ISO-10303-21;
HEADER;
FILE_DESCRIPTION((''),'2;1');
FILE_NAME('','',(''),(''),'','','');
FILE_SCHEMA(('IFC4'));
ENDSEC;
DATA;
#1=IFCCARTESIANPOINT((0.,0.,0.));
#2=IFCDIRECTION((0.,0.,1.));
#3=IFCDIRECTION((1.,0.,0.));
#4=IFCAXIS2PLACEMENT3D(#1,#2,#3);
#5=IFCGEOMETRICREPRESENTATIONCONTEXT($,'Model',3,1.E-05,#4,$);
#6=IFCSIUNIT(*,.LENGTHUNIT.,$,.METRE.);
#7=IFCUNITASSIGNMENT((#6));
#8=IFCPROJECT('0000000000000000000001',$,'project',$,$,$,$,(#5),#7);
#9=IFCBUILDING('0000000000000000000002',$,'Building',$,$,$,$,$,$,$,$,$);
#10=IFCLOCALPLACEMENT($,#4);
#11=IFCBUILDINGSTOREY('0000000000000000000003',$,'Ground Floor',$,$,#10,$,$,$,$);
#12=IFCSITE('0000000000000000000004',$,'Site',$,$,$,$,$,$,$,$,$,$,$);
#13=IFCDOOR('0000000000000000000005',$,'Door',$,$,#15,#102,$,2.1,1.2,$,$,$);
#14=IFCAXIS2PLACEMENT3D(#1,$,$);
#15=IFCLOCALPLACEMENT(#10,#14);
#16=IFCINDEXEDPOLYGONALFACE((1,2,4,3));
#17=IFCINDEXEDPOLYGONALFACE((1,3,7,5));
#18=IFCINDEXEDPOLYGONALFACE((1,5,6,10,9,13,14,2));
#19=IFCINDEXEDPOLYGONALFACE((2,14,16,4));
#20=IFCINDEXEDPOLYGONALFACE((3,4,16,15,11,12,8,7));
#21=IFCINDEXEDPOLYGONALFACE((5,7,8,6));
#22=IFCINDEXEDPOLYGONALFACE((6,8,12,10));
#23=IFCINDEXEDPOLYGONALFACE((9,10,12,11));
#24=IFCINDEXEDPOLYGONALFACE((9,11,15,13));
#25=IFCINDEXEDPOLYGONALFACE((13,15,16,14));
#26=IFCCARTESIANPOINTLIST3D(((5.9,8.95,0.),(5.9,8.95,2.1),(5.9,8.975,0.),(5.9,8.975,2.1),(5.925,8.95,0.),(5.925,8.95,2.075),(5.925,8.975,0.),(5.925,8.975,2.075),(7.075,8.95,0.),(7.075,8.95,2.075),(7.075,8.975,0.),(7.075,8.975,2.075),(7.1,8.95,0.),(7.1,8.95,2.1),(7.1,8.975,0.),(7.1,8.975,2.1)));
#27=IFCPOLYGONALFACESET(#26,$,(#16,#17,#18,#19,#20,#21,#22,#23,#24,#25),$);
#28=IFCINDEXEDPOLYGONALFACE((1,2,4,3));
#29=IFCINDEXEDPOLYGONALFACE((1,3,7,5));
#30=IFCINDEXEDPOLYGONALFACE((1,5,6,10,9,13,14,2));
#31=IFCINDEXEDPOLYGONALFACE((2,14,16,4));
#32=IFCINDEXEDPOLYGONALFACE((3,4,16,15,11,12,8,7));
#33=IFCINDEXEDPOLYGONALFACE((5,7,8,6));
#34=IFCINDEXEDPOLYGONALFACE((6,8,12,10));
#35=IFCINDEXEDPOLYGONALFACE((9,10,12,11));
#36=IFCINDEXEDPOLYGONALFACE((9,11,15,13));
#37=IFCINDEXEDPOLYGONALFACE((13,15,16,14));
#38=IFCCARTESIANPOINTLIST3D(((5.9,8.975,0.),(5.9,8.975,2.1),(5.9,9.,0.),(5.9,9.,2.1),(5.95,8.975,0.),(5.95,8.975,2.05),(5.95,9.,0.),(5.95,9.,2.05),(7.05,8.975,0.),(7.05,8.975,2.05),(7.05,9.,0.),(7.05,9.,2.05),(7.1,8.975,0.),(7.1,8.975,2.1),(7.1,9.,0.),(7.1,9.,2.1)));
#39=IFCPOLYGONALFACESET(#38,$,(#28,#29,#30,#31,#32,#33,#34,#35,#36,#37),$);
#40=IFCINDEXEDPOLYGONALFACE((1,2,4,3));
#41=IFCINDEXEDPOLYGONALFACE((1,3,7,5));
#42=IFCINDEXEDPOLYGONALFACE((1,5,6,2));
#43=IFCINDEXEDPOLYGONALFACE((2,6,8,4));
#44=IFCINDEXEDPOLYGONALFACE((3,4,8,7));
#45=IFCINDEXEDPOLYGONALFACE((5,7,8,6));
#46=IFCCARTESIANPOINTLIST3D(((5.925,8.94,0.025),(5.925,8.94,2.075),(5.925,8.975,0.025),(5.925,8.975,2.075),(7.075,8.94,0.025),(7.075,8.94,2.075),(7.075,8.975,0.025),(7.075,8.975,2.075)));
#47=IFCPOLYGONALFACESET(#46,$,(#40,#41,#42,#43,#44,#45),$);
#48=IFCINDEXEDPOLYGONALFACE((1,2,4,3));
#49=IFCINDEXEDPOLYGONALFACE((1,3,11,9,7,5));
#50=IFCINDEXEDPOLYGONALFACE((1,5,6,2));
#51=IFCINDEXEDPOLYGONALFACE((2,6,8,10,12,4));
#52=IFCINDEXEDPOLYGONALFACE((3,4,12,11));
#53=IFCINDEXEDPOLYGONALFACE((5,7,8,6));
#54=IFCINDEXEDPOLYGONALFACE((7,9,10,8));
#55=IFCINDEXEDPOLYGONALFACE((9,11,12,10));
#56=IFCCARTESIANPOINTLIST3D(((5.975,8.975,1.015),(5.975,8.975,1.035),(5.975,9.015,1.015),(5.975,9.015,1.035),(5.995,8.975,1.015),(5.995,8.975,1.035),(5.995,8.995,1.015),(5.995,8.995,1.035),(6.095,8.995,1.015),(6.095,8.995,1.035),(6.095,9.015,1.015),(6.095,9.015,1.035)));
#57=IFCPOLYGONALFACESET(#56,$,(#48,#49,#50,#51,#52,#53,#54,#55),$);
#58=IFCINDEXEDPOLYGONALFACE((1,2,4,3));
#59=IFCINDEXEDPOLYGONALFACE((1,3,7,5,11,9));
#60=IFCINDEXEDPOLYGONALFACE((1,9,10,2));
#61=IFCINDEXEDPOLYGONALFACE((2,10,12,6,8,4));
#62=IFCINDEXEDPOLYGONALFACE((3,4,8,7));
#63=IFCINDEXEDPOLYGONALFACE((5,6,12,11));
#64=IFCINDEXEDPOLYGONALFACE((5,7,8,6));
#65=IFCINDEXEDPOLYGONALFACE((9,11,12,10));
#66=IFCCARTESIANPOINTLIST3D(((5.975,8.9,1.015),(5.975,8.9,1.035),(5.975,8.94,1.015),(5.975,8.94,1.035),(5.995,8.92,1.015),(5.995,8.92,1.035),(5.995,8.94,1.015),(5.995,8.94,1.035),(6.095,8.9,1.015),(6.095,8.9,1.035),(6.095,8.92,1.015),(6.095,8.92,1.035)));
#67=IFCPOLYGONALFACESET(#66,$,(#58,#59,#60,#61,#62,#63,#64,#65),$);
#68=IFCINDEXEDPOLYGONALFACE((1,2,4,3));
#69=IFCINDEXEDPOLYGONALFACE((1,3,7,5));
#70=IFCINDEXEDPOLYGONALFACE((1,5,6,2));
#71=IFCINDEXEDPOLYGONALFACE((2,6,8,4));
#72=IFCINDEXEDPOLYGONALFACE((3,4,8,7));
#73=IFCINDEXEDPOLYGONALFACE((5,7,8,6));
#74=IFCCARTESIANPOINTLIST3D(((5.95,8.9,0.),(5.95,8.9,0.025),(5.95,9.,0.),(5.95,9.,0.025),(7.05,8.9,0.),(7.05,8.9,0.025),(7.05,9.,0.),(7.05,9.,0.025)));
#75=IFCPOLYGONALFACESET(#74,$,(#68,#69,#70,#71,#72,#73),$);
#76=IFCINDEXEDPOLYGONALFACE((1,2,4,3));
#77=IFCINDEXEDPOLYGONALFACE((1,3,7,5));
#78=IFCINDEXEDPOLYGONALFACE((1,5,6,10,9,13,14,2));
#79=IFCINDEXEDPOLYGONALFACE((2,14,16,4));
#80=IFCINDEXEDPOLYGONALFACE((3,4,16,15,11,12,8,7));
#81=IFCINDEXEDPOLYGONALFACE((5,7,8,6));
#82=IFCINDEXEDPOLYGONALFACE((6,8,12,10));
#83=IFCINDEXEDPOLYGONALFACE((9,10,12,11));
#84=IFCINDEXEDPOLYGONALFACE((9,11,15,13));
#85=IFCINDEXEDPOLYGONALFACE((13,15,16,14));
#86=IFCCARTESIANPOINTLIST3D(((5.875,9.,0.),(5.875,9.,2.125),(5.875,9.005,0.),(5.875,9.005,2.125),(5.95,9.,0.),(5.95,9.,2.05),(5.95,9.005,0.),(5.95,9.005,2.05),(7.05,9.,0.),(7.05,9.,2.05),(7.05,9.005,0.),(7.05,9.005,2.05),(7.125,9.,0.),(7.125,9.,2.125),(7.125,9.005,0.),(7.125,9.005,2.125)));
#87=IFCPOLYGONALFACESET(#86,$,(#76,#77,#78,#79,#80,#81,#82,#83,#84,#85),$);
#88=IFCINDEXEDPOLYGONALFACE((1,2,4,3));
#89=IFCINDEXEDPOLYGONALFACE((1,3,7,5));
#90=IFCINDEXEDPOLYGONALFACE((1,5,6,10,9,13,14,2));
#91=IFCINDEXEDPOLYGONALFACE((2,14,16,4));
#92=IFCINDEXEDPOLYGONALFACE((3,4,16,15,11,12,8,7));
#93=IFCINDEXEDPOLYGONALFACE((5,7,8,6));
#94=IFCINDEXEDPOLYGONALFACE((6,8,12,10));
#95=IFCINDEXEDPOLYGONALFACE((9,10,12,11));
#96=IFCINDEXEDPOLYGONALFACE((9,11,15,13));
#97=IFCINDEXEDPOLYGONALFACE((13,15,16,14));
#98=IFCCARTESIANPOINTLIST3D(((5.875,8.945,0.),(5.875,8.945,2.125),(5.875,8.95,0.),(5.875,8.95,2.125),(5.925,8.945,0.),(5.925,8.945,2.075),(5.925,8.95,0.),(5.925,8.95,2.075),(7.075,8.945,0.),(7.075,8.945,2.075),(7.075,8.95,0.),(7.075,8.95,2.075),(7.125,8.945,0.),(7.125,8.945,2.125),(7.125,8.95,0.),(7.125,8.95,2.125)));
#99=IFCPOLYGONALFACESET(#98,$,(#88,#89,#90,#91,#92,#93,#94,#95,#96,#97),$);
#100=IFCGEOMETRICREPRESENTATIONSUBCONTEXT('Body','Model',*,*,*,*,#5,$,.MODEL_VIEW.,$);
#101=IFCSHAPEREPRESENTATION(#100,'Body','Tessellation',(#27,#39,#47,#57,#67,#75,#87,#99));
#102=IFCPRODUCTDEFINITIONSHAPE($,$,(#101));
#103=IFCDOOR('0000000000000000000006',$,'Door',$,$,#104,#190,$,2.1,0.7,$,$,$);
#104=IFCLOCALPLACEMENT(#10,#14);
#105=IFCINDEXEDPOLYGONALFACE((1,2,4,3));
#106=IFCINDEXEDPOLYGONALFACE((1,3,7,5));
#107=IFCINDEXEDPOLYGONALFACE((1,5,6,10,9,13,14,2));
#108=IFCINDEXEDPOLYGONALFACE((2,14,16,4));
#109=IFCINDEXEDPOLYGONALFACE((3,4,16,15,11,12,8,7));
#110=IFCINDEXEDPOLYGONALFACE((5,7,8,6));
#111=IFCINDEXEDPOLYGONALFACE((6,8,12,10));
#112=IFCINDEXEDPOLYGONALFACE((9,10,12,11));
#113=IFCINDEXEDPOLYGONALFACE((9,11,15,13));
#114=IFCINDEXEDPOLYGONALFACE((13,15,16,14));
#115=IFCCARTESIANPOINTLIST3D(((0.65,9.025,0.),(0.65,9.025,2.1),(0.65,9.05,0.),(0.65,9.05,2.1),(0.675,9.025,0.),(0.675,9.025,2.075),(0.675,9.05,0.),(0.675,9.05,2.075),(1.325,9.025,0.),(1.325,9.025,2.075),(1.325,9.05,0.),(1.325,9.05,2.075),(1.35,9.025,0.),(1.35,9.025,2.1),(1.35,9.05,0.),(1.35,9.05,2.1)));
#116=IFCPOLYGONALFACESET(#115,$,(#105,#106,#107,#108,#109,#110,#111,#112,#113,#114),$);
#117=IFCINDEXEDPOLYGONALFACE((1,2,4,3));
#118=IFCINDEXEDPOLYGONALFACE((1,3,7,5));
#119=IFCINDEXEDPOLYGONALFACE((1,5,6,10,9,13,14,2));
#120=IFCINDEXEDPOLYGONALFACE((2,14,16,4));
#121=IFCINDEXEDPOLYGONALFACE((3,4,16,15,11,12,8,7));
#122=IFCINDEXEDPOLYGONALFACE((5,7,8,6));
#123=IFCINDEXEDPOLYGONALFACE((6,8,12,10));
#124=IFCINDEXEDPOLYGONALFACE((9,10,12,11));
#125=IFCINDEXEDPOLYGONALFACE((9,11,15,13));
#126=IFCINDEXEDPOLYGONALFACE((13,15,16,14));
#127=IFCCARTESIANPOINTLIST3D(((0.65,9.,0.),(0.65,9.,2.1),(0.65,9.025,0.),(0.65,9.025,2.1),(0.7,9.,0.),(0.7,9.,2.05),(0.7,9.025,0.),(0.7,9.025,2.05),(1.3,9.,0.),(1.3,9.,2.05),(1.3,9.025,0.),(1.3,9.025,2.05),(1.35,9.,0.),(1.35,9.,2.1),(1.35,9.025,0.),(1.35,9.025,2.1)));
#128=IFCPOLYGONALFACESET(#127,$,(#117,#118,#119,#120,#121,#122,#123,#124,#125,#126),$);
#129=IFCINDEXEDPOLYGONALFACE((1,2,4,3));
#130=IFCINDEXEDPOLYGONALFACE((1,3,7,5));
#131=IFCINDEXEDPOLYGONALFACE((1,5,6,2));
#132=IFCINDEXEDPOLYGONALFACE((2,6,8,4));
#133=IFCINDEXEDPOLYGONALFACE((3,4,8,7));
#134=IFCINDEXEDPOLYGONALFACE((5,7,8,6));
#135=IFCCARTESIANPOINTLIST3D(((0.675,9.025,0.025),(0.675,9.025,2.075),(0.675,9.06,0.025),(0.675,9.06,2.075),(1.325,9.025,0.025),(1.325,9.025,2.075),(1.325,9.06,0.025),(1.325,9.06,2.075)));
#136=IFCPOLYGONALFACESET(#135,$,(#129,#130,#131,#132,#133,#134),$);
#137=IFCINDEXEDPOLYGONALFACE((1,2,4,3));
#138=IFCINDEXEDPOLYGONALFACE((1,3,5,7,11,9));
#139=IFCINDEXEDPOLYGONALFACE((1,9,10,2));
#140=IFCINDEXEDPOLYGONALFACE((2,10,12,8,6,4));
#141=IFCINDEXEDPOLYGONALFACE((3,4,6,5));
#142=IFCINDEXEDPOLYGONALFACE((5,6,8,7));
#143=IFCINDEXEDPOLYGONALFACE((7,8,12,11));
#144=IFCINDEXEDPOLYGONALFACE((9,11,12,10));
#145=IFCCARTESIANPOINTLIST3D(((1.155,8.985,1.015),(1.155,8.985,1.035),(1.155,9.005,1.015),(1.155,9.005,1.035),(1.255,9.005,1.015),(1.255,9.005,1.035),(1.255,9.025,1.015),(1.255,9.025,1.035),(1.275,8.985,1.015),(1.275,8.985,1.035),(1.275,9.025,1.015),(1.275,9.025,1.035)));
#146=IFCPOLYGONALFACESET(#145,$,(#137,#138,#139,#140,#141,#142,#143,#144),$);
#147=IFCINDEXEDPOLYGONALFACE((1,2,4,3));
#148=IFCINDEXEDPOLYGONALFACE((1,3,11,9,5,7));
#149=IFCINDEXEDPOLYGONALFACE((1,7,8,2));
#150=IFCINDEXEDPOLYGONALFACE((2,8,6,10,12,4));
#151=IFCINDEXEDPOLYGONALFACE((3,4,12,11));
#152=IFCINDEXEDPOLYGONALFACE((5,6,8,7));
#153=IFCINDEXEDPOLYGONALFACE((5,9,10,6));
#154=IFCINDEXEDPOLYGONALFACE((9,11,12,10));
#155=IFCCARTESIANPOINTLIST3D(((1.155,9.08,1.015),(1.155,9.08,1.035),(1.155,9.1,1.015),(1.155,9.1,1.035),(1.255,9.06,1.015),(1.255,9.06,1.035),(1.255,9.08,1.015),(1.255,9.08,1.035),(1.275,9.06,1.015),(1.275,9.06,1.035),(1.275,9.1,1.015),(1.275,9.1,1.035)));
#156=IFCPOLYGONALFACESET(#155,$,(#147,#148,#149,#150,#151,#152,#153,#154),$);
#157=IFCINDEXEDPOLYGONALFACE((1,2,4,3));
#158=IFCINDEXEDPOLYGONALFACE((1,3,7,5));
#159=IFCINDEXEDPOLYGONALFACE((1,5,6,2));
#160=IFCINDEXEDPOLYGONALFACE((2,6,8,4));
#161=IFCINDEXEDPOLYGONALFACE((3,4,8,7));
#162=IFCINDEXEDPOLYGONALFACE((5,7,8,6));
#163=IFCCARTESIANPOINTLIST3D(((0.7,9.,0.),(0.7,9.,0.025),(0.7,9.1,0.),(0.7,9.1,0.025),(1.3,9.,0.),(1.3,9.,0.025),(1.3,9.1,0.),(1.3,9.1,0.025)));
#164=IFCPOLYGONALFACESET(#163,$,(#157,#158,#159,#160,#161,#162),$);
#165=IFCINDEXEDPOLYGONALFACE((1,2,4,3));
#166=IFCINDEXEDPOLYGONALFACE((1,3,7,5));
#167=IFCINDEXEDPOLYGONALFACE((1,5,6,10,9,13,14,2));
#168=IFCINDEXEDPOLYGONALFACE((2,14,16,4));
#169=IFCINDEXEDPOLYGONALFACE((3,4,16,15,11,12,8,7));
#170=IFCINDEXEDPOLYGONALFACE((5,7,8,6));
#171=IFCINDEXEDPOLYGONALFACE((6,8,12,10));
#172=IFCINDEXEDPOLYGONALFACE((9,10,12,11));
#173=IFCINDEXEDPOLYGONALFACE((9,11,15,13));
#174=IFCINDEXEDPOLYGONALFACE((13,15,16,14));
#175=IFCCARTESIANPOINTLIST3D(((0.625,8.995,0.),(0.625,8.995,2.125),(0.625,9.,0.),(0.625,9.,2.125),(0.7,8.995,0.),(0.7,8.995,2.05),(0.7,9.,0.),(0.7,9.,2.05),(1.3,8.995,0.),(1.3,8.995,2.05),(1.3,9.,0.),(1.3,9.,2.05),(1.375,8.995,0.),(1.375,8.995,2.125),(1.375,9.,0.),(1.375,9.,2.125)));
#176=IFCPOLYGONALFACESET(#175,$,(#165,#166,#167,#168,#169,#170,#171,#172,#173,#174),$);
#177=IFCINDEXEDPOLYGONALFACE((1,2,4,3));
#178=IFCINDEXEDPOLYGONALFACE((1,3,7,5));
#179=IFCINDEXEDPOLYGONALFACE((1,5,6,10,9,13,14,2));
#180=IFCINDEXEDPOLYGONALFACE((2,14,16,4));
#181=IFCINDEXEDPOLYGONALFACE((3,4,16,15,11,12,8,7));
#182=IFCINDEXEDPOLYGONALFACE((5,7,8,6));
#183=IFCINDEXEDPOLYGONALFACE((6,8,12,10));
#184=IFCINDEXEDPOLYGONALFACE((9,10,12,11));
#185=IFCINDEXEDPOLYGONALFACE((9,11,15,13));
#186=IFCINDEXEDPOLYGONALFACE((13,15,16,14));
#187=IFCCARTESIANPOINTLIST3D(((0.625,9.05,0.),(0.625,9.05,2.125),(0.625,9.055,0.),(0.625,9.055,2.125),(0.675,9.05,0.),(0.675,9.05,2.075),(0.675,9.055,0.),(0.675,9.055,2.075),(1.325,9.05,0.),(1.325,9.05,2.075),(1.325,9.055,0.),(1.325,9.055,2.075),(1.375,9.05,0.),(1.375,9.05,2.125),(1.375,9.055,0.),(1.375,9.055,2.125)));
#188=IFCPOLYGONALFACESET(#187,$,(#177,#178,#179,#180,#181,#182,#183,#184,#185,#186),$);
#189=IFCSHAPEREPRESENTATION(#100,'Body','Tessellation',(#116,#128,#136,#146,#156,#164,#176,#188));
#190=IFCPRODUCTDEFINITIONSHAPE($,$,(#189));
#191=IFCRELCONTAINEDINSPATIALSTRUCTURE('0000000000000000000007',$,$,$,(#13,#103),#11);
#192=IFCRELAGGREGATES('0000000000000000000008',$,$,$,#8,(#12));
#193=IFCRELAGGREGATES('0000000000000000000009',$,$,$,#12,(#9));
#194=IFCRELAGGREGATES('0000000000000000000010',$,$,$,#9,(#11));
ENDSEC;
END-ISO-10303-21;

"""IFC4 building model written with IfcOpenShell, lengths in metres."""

from ifc_helpers import new_model, si_unit, frame, origin_with_axes, place, context, subcontext, project, spatial, line, indexed_curve, outline, extrude, element, save


model = new_model("IFC4")

# Units and contexts
model_context = context("Model", 3, precision=1e-05, world=origin_with_axes())
body_context = subcontext(model_context, "Body", "Model", "MODEL_VIEW")
ifc_project = project(units=[si_unit("LENGTHUNIT", "METRE")], contexts=[model_context])

# Site, building, storey
site = spatial("IfcSite", under=ifc_project, Name="Site")
building = spatial("IfcBuilding", under=site, Name="Building")
storey_placement = place(None, origin_with_axes())
storey = spatial("IfcBuildingStorey", under=building, at=storey_placement, Name="Ground Floor")

# Doors
door_1_placement = place(storey_placement, frame((7.1, 9.0, 0.0), z_axis=(0.0, 0.0, 1.0), x_axis=(-1.0, 0.0, 0.0)))
element("IfcDoor", 1, at=door_1_placement, inside=storey, Name="Door", OverallHeight=2.1, OverallWidth=1.2, context=body_context, shape_type="SweptSolid", body=[
    extrude(outline(indexed_curve([(0.0, 0.0), (0.0, 2.1), (1.2, 2.1), (1.2, 0.0), (1.175, 0.0), (1.175, 2.075), (0.025, 2.075), (0.025, 0.0)], segments=[line(1, 2, 3, 4, 5, 6, 7, 8, 1)])), frame((0.0, 0.025, 0.0), z_axis=(0.0, -1.0, 0.0), x_axis=(1.0, 0.0, 0.0)), (0.0, 0.0, -1.0), 0.025),
    extrude(outline(indexed_curve([(0.0, 0.0), (0.0, 2.1), (1.2, 2.1), (1.2, 0.0), (1.15, 0.0), (1.15, 2.05), (0.05, 2.05), (0.05, 0.0)], segments=[line(1, 2, 3, 4, 5, 6, 7, 8, 1)])), frame((0.0, 0.0, 0.0), z_axis=(0.0, -1.0, 0.0), x_axis=(1.0, 0.0, 0.0)), (0.0, 0.0, -1.0), 0.025),
    extrude(outline(indexed_curve([(0.0, 0.0), (1.15, 0.0), (1.15, 0.035), (0.0, 0.035)], segments=[line(1, 2, 3, 4, 1)])), frame((0.025, 0.025, 0.025), z_axis=(0.0, 0.0, 1.0), x_axis=(1.0, 0.0, 0.0)), (0.0, 0.0, 1.0), 2.05),
    extrude(outline(indexed_curve([(0.0, 0.0), (0.0, -0.04), (-0.12, -0.04), (-0.12, -0.02), (-0.02, -0.02), (-0.02, 0.0)], segments=[line(1, 2, 3, 4, 5, 6, 1)])), frame((1.125, 0.025, 1.015), z_axis=(0.0, 0.0, 1.0), x_axis=(1.0, 0.0, 0.0)), (0.0, 0.0, 1.0), 0.02),
    extrude(outline(indexed_curve([(0.0, 0.0), (0.0, 0.04), (-0.12, 0.04), (-0.12, 0.02), (-0.02, 0.02), (-0.02, 0.0)], segments=[line(1, 2, 3, 4, 5, 6, 1)])), frame((1.125, 0.06, 1.015), z_axis=(0.0, 0.0, 1.0), x_axis=(1.0, 0.0, 0.0)), (0.0, 0.0, 1.0), 0.02),
    extrude(outline(indexed_curve([(0.0, 0.0), (1.1, 0.0), (1.1, 0.1), (0.0, 0.1)], segments=[line(1, 2, 3, 4, 1)])), frame((0.05, 0.0, 0.0), z_axis=(0.0, 0.0, 1.0), x_axis=(1.0, 0.0, 0.0)), (0.0, 0.0, 1.0), 0.025),
    extrude(outline(indexed_curve([(0.0, 0.0), (0.0, 2.125), (1.25, 2.125), (1.25, 0.0), (1.175, 0.0), (1.175, 2.05), (0.075, 2.05), (0.075, 0.0)], segments=[line(1, 2, 3, 4, 5, 6, 7, 8, 1)])), frame((-0.025, -0.005, 0.0), z_axis=(0.0, -1.0, 0.0), x_axis=(1.0, 0.0, 0.0)), (0.0, 0.0, -1.0), 0.005),
    extrude(outline(indexed_curve([(0.0, 0.0), (0.0, 2.125), (1.25, 2.125), (1.25, 0.0), (1.2, 0.0), (1.2, 2.075), (0.05, 2.075), (0.05, 0.0)], segments=[line(1, 2, 3, 4, 5, 6, 7, 8, 1)])), frame((-0.025, 0.05, 0.0), z_axis=(0.0, -1.0, 0.0), x_axis=(1.0, 0.0, 0.0)), (0.0, 0.0, -1.0), 0.005),
])
door_2_placement = place(storey_placement, frame((0.65, 9.0, 0.0), z_axis=(0.0, 0.0, 1.0), x_axis=(1.0, 0.0, 0.0)))
element("IfcDoor", 2, at=door_2_placement, inside=storey, Name="Door", OverallHeight=2.1, OverallWidth=0.7, context=body_context, shape_type="SweptSolid", body=[
    extrude(outline(indexed_curve([(0.0, 0.0), (0.0, 2.1), (0.7, 2.1), (0.7, 0.0), (0.675, 0.0), (0.675, 2.075), (0.025, 2.075), (0.025, 0.0)], segments=[line(1, 2, 3, 4, 5, 6, 7, 8, 1)])), frame((0.0, 0.025, 0.0), z_axis=(0.0, -1.0, 0.0), x_axis=(1.0, 0.0, 0.0)), (0.0, 0.0, -1.0), 0.025),
    extrude(outline(indexed_curve([(0.0, 0.0), (0.0, 2.1), (0.7, 2.1), (0.7, 0.0), (0.65, 0.0), (0.65, 2.05), (0.05, 2.05), (0.05, 0.0)], segments=[line(1, 2, 3, 4, 5, 6, 7, 8, 1)])), frame((0.0, 0.0, 0.0), z_axis=(0.0, -1.0, 0.0), x_axis=(1.0, 0.0, 0.0)), (0.0, 0.0, -1.0), 0.025),
    extrude(outline(indexed_curve([(0.0, 0.0), (0.65, 0.0), (0.65, 0.035), (0.0, 0.035)], segments=[line(1, 2, 3, 4, 1)])), frame((0.025, 0.025, 0.025), z_axis=(0.0, 0.0, 1.0), x_axis=(1.0, 0.0, 0.0)), (0.0, 0.0, 1.0), 2.05),
    extrude(outline(indexed_curve([(0.0, 0.0), (0.0, -0.04), (-0.12, -0.04), (-0.12, -0.02), (-0.02, -0.02), (-0.02, 0.0)], segments=[line(1, 2, 3, 4, 5, 6, 1)])), frame((0.625, 0.025, 1.015), z_axis=(0.0, 0.0, 1.0), x_axis=(1.0, 0.0, 0.0)), (0.0, 0.0, 1.0), 0.02),
    extrude(outline(indexed_curve([(0.0, 0.0), (0.0, 0.04), (-0.12, 0.04), (-0.12, 0.02), (-0.02, 0.02), (-0.02, 0.0)], segments=[line(1, 2, 3, 4, 5, 6, 1)])), frame((0.625, 0.06, 1.015), z_axis=(0.0, 0.0, 1.0), x_axis=(1.0, 0.0, 0.0)), (0.0, 0.0, 1.0), 0.02),
    extrude(outline(indexed_curve([(0.0, 0.0), (0.6, 0.0), (0.6, 0.1), (0.0, 0.1)], segments=[line(1, 2, 3, 4, 1)])), frame((0.05, 0.0, 0.0), z_axis=(0.0, 0.0, 1.0), x_axis=(1.0, 0.0, 0.0)), (0.0, 0.0, 1.0), 0.025),
    extrude(outline(indexed_curve([(0.0, 0.0), (0.0, 2.125), (0.75, 2.125), (0.75, 0.0), (0.675, 0.0), (0.675, 2.05), (0.075, 2.05), (0.075, 0.0)], segments=[line(1, 2, 3, 4, 5, 6, 7, 8, 1)])), frame((-0.025, -0.005, 0.0), z_axis=(0.0, -1.0, 0.0), x_axis=(1.0, 0.0, 0.0)), (0.0, 0.0, -1.0), 0.005),
    extrude(outline(indexed_curve([(0.0, 0.0), (0.0, 2.125), (0.75, 2.125), (0.75, 0.0), (0.7, 0.0), (0.7, 2.075), (0.05, 2.075), (0.05, 0.0)], segments=[line(1, 2, 3, 4, 5, 6, 7, 8, 1)])), frame((-0.025, 0.05, 0.0), z_axis=(0.0, -1.0, 0.0), x_axis=(1.0, 0.0, 0.0)), (0.0, 0.0, -1.0), 0.005),
])

save(model, "model.ifc")
